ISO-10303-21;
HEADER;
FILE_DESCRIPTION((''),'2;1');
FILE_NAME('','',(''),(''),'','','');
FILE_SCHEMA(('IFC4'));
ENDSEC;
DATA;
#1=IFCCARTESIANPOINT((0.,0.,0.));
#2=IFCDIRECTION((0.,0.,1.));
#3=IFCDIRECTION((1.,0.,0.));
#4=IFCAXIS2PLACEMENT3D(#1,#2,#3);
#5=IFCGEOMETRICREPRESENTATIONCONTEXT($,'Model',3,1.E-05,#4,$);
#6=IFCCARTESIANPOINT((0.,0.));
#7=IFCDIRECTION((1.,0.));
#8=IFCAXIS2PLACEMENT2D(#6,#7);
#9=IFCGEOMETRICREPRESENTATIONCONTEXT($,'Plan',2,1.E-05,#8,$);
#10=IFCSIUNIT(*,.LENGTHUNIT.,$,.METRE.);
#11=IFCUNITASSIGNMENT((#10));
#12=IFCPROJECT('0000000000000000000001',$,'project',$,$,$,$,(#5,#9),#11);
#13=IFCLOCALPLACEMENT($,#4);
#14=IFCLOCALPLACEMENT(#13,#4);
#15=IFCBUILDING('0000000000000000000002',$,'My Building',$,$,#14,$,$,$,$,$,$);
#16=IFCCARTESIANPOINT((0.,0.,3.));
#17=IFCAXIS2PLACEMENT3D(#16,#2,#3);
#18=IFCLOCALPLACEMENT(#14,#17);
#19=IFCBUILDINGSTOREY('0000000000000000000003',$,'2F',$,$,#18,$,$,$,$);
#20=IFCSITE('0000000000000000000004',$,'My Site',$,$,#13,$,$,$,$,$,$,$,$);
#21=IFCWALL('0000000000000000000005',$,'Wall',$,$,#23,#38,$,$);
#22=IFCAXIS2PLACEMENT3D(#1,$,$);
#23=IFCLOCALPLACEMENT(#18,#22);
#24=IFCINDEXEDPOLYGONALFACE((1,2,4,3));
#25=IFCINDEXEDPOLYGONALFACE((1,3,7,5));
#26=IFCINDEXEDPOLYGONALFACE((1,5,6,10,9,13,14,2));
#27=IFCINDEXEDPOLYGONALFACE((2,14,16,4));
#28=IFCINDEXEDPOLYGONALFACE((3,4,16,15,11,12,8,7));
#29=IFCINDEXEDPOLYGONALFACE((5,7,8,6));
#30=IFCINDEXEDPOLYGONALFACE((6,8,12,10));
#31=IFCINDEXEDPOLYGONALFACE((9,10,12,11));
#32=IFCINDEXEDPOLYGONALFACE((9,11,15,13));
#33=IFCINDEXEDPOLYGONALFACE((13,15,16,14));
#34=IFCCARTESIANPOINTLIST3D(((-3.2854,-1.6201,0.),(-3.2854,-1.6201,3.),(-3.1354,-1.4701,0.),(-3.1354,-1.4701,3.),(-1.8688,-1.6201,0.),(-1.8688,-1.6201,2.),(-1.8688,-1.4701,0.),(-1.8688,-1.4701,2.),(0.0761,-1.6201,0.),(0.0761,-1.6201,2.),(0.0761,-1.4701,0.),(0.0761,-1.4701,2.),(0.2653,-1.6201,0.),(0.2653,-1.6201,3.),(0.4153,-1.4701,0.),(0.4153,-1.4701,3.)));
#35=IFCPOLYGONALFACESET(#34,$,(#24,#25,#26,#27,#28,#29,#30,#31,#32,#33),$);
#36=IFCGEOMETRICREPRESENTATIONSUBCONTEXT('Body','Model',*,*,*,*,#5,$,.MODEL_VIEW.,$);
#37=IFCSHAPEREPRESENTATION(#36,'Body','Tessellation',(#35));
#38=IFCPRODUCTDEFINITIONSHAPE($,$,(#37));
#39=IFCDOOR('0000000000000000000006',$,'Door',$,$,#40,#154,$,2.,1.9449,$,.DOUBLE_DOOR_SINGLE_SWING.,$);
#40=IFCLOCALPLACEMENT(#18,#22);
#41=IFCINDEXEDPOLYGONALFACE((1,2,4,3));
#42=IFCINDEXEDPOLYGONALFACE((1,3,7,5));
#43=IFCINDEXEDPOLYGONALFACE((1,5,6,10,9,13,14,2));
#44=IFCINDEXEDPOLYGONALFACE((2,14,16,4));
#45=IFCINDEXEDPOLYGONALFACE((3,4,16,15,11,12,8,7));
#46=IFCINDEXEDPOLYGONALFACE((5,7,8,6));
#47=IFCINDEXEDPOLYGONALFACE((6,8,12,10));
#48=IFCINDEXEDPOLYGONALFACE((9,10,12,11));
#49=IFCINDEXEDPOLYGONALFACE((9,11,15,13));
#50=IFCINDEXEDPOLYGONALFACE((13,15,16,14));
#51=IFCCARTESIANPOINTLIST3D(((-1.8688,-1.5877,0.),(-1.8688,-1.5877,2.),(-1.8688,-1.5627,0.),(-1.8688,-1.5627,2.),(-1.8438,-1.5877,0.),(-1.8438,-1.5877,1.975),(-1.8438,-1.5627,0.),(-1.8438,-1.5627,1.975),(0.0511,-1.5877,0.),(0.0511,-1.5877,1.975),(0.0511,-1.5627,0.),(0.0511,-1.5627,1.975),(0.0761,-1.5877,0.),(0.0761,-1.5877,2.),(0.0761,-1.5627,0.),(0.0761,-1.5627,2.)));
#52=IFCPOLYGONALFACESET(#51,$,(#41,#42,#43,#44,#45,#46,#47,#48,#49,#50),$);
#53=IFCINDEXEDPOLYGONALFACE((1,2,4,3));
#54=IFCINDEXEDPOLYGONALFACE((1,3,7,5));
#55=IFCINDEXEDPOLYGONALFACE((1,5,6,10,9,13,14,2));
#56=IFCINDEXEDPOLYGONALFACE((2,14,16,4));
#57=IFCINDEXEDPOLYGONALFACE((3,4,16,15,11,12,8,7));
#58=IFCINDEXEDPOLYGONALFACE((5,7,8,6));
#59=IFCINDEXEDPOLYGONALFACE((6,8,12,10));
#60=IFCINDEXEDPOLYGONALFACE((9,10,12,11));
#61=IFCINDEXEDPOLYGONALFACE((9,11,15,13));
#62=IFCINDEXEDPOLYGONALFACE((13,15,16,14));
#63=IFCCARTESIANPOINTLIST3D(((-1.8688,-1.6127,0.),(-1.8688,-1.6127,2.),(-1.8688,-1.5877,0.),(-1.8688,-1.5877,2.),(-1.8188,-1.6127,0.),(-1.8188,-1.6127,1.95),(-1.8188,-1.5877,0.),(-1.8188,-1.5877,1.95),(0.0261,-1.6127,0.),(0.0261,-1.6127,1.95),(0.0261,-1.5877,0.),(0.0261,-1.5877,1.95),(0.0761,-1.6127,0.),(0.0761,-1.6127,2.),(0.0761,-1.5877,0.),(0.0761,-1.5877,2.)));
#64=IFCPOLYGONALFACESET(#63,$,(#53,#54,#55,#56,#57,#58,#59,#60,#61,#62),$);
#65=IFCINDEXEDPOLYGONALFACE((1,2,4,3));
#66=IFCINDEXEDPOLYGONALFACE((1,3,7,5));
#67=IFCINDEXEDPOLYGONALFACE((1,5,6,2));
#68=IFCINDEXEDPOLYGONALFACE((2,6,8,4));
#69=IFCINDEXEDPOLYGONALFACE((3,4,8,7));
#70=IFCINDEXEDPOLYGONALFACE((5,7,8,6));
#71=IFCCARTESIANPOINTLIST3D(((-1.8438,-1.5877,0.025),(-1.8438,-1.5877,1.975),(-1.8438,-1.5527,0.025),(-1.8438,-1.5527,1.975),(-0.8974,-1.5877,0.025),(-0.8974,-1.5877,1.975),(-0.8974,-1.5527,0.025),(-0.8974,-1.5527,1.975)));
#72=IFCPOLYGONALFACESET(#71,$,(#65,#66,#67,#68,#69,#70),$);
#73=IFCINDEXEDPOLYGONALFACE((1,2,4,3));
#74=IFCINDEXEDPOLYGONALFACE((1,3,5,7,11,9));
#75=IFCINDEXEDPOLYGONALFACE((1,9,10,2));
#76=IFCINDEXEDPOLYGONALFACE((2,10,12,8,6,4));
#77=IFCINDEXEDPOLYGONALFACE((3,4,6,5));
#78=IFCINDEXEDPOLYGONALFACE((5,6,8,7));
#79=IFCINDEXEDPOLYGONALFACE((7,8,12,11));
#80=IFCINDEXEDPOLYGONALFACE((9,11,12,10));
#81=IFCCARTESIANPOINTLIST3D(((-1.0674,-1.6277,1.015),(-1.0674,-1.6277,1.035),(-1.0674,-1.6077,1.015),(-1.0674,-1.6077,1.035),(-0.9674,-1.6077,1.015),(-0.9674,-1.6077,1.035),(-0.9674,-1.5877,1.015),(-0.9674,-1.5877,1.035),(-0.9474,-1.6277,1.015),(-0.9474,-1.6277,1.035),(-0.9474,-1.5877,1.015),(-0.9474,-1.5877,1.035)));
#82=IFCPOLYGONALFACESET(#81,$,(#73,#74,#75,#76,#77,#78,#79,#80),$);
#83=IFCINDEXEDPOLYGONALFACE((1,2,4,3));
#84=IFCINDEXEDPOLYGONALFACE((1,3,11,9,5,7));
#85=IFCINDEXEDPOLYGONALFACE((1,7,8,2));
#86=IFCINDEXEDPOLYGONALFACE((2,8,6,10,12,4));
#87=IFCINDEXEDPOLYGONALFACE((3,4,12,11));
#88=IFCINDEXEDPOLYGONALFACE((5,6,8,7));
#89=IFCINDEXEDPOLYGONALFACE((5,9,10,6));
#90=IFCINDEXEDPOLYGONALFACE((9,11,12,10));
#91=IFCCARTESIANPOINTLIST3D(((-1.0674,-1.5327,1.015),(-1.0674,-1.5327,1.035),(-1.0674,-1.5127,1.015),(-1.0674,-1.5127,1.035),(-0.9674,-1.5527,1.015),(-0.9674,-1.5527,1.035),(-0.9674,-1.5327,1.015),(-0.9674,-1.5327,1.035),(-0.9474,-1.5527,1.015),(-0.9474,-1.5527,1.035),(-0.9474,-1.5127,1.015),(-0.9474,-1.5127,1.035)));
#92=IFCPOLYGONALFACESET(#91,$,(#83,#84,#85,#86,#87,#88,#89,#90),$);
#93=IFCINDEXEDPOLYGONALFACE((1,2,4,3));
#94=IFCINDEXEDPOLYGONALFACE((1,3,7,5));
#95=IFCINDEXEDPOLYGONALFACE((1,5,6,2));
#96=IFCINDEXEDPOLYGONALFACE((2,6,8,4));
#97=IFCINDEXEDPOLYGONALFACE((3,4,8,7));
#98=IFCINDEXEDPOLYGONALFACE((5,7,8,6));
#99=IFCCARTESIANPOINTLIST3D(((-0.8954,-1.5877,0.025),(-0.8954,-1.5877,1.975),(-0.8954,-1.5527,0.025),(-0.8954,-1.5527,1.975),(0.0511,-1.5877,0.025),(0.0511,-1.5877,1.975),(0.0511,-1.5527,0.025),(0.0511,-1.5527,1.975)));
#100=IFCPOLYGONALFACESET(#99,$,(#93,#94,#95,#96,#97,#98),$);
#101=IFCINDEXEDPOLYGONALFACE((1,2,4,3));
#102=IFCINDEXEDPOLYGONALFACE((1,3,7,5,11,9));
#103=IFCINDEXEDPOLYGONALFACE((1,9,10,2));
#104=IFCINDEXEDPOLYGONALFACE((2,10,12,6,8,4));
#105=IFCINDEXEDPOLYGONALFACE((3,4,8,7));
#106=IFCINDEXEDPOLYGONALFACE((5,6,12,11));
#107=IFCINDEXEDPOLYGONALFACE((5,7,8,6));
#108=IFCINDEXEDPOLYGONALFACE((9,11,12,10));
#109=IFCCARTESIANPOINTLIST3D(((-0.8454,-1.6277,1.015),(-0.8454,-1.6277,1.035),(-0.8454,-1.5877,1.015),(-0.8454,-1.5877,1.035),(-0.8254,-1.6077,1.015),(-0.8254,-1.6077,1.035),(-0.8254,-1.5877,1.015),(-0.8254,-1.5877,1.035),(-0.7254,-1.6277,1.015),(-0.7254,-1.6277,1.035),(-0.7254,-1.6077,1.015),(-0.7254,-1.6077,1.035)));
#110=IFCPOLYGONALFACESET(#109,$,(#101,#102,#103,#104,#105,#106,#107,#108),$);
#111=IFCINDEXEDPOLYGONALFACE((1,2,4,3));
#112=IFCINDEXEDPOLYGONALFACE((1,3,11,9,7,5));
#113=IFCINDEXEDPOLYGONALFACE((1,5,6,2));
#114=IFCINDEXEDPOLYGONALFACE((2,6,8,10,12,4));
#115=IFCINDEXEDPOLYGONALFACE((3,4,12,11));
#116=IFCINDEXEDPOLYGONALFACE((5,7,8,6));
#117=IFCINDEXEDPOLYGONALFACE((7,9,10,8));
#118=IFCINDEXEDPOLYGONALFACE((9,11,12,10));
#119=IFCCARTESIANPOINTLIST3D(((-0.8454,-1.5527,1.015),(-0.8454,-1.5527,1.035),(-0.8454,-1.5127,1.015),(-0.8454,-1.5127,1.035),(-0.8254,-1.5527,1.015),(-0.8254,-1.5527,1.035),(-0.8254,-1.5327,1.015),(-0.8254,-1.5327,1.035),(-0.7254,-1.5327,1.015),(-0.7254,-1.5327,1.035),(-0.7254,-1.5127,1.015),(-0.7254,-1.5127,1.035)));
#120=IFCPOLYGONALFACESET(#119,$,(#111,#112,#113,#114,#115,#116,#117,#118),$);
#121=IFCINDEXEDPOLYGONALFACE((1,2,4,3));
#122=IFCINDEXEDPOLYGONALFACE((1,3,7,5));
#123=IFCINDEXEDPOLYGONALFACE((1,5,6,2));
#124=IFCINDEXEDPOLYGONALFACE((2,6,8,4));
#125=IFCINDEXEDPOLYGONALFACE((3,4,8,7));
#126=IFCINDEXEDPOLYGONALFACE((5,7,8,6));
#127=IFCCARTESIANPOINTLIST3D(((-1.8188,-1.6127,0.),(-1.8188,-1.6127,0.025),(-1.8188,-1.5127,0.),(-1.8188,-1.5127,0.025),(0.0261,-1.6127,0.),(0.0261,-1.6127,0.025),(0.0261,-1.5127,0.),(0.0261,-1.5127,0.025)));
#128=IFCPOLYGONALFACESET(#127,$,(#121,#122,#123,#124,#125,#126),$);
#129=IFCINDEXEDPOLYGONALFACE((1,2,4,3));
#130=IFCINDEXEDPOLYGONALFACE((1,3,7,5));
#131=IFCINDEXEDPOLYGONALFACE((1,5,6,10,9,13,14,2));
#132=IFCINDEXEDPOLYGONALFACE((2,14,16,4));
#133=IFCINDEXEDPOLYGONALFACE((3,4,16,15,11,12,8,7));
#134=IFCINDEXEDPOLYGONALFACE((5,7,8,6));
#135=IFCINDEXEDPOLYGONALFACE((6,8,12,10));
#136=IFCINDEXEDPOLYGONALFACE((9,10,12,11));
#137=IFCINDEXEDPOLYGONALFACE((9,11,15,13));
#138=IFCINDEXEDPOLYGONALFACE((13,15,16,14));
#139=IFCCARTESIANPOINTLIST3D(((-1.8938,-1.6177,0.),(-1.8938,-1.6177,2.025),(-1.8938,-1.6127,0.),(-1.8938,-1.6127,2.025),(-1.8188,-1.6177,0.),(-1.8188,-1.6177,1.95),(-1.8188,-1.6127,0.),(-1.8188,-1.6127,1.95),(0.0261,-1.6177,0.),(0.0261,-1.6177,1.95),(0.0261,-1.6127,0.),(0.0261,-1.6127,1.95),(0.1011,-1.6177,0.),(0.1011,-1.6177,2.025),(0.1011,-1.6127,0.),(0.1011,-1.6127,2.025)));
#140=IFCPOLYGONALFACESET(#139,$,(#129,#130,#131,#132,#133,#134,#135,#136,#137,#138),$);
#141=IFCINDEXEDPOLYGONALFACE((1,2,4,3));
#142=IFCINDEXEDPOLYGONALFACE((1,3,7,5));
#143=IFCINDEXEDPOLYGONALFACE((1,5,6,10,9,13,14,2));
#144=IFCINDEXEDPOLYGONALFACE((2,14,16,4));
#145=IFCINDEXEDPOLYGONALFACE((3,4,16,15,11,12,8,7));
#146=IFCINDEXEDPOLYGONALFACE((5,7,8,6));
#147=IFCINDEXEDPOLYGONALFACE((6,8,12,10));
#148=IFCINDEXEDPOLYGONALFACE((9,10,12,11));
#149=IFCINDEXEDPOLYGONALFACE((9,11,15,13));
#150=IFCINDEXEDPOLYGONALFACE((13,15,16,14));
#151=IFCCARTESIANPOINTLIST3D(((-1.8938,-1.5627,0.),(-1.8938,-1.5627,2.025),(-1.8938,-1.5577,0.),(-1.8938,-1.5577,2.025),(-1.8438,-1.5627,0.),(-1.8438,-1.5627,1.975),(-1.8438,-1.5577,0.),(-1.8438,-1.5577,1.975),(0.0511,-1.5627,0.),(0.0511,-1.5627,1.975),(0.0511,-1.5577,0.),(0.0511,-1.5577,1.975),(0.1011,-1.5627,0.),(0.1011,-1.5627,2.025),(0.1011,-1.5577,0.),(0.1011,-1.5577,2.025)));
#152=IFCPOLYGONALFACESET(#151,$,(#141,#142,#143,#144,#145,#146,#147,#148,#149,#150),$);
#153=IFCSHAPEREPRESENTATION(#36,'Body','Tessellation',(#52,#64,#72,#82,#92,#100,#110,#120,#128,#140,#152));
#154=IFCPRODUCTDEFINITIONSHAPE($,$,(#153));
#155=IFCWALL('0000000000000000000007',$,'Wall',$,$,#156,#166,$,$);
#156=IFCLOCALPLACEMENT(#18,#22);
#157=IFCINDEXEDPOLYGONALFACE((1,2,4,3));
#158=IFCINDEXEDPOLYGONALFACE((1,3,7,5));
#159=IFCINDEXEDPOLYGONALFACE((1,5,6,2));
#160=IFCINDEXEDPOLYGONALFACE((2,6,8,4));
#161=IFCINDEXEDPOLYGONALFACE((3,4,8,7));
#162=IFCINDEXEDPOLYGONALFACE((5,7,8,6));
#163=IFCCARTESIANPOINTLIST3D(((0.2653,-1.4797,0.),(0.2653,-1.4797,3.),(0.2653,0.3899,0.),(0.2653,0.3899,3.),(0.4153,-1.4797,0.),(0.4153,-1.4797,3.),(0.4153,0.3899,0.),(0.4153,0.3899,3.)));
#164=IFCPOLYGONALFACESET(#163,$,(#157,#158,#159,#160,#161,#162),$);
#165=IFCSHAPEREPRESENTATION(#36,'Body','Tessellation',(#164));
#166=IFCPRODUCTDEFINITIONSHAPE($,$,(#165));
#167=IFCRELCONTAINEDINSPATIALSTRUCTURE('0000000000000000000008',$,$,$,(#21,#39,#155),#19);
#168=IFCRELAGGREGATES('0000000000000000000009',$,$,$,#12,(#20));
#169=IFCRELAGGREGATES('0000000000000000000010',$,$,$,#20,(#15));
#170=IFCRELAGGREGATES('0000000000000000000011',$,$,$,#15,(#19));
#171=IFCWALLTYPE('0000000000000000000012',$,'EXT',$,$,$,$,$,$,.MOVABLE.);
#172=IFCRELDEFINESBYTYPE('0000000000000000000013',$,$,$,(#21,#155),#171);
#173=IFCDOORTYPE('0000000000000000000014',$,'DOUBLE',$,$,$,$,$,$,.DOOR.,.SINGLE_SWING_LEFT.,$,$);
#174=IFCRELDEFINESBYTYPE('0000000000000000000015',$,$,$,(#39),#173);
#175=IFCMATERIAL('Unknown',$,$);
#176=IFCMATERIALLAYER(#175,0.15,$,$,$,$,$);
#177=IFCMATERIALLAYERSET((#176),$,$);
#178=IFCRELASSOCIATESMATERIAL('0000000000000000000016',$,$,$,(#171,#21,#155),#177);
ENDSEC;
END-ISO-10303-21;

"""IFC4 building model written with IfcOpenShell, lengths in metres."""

from ifc_helpers import new_model, entity, si_unit, frame, origin_with_axes, origin_2d_with_axis, place, context, subcontext, project, spatial, line, indexed_curve, outline, extrude, shape, source, transform, mapped, material, layer, layer_set, layer_usage, type_object, type_shapes, element, fill, save


model = new_model("IFC4")

# Units and contexts
model_context = context("Model", 3, precision=1e-05, world=origin_with_axes())
plan_context = context("Plan", 2, precision=1e-05, world=origin_2d_with_axis())
body_context_1 = subcontext(model_context, "Body", "Model", "MODEL_VIEW")
body_context_2 = subcontext(plan_context, "Body", "Plan", "PLAN_VIEW")
ifc_project = project(units=[si_unit("LENGTHUNIT", "METRE")], contexts=[model_context, plan_context])

# Site, building, storey
site_placement = place(None, origin_with_axes())
site = spatial("IfcSite", under=ifc_project, at=site_placement, Name="My Site")
building_placement = place(site_placement, origin_with_axes())
building = spatial("IfcBuilding", under=site, at=building_placement, Name="My Building")
storey_placement = place(building_placement, frame((0.0, 0.0, 3.0), z_axis=(0.0, 0.0, 1.0), x_axis=(1.0, 0.0, 0.0)))
storey = spatial("IfcBuildingStorey", under=building, at=storey_placement, Name="2F")

# Shared definitions
ifc_material = material(Name="Unknown")

# Shared definitions
ifc_layer_1 = layer(ifc_material, 0.15)
ifc_layer_set_1 = layer_set([ifc_layer_1])
wall_type_1 = type_object("IfcWallType", Name="EXT", PredefinedType="MOVABLE", material=ifc_layer_set_1)

# Wall, opening, door
ifc_layer_usage_1 = layer_usage(ifc_layer_set_1, "AXIS2", "POSITIVE", -0.15)
wall_1_placement = place(storey_placement, frame((0.2653, -1.6201, 0.0), z_axis=(0.0, 0.0, 1.0), x_axis=(-1.0, 0.0, 0.0)))
wall_1 = element("IfcWall", 1, at=wall_1_placement, inside=storey, type_object=wall_type_1, material=ifc_layer_usage_1, Name="Wall", context=body_context_1, shape_type="SweptSolid", body=[
    extrude(outline(indexed_curve([(-0.15, -0.15), (0.0, 0.0), (3.5507, 0.0), (3.4007, -0.15)], segments=[line(1, 2, 3, 4, 1)])), origin_with_axes(), (0.0, 0.0, 1.0), 3.0),
])
placement_1 = place(storey_placement, frame((-1.8688, -1.6127, 0.0), z_axis=(0.0, 0.0, 1.0), x_axis=(1.0, 0.0, 0.0)))
opening_1 = element("IfcOpeningElement", 2, at=placement_1, cuts=wall_1, PredefinedType="OPENING", context=body_context_1, shape_type="SweptSolid", body=[
    extrude(outline(indexed_curve([(0.0, 0.0), (1.9449, 0.0), (1.9449, 2.0), (0.0, 2.0)], segments=[line(1, 2, 3, 4, 1)])), frame((0.0, -0.6, 0.0), z_axis=(0.0, -1.0, 0.0), x_axis=(1.0, 0.0, 0.0)), (0.0, 0.0, -1.0), 1.2),
])
door_type_1 = type_object("IfcDoorType", Name="DOUBLE", OperationType="SINGLE_SWING_LEFT", PredefinedType="DOOR")
shared_shape_1 = source(origin_with_axes(), body_context_1, "Body", "SweptSolid", [
    extrude(outline(indexed_curve([(0.0, 0.0), (0.0, 2.0), (1.9449, 2.0), (1.9449, 0.0), (1.9199, 0.0), (1.9199, 1.975), (0.025, 1.975), (0.025, 0.0)], segments=[line(1, 2, 3, 4, 5, 6, 7, 8, 1)])), frame((0.0, 0.025, 0.0), z_axis=(0.0, -1.0, 0.0), x_axis=(1.0, 0.0, 0.0)), (0.0, 0.0, -1.0), 0.025),
    extrude(outline(indexed_curve([(0.0, 0.0), (0.0, 2.0), (1.9449, 2.0), (1.9449, 0.0), (1.8949, 0.0), (1.8949, 1.95), (0.05, 1.95), (0.05, 0.0)], segments=[line(1, 2, 3, 4, 5, 6, 7, 8, 1)])), frame((0.0, 0.0, 0.0), z_axis=(0.0, -1.0, 0.0), x_axis=(1.0, 0.0, 0.0)), (0.0, 0.0, -1.0), 0.025),
    extrude(outline(indexed_curve([(0.0, 0.0), (0.9465, 0.0), (0.9465, 0.035), (0.0, 0.035)], segments=[line(1, 2, 3, 4, 1)])), frame((0.025, 0.025, 0.025), z_axis=(0.0, 0.0, 1.0), x_axis=(1.0, 0.0, 0.0)), (0.0, 0.0, 1.0), 1.95),
    extrude(outline(indexed_curve([(0.0, 0.0), (0.0, -0.04), (-0.12, -0.04), (-0.12, -0.02), (-0.02, -0.02), (-0.02, 0.0)], segments=[line(1, 2, 3, 4, 5, 6, 1)])), frame((0.9215, 0.025, 1.015), z_axis=(0.0, 0.0, 1.0), x_axis=(1.0, 0.0, 0.0)), (0.0, 0.0, 1.0), 0.02),
    extrude(outline(indexed_curve([(0.0, 0.0), (0.0, 0.04), (-0.12, 0.04), (-0.12, 0.02), (-0.02, 0.02), (-0.02, 0.0)], segments=[line(1, 2, 3, 4, 5, 6, 1)])), frame((0.9215, 0.06, 1.015), z_axis=(0.0, 0.0, 1.0), x_axis=(1.0, 0.0, 0.0)), (0.0, 0.0, 1.0), 0.02),
    extrude(outline(indexed_curve([(0.0, 0.0), (-0.9465, 0.0), (-0.9465, 0.035), (0.0, 0.035)], segments=[line(1, 2, 3, 4, 1)])), frame((1.9199, 0.025, 0.025), z_axis=(0.0, 0.0, 1.0), x_axis=(1.0, 0.0, 0.0)), (0.0, 0.0, 1.0), 1.95),
    extrude(outline(indexed_curve([(0.0, 0.0), (0.0, -0.04), (0.12, -0.04), (0.12, -0.02), (0.02, -0.02), (0.02, 0.0)], segments=[line(1, 2, 3, 4, 5, 6, 1)])), frame((1.0235, 0.025, 1.015), z_axis=(0.0, 0.0, 1.0), x_axis=(1.0, 0.0, 0.0)), (0.0, 0.0, 1.0), 0.02),
    extrude(outline(indexed_curve([(0.0, 0.0), (0.0, 0.04), (0.12, 0.04), (0.12, 0.02), (0.02, 0.02), (0.02, 0.0)], segments=[line(1, 2, 3, 4, 5, 6, 1)])), frame((1.0235, 0.06, 1.015), z_axis=(0.0, 0.0, 1.0), x_axis=(1.0, 0.0, 0.0)), (0.0, 0.0, 1.0), 0.02),
    extrude(outline(indexed_curve([(0.0, 0.0), (1.8449, 0.0), (1.8449, 0.1), (0.0, 0.1)], segments=[line(1, 2, 3, 4, 1)])), frame((0.05, 0.0, 0.0), z_axis=(0.0, 0.0, 1.0), x_axis=(1.0, 0.0, 0.0)), (0.0, 0.0, 1.0), 0.025),
    extrude(outline(indexed_curve([(0.0, 0.0), (0.0, 2.025), (1.9949, 2.025), (1.9949, 0.0), (1.9199, 0.0), (1.9199, 1.95), (0.075, 1.95), (0.075, 0.0)], segments=[line(1, 2, 3, 4, 5, 6, 7, 8, 1)])), frame((-0.025, -0.005, 0.0), z_axis=(0.0, -1.0, 0.0), x_axis=(1.0, 0.0, 0.0)), (0.0, 0.0, -1.0), 0.005),
    extrude(outline(indexed_curve([(0.0, 0.0), (0.0, 2.025), (1.9949, 2.025), (1.9949, 0.0), (1.9449, 0.0), (1.9449, 1.975), (0.05, 1.975), (0.05, 0.0)], segments=[line(1, 2, 3, 4, 5, 6, 7, 8, 1)])), frame((-0.025, 0.05, 0.0), z_axis=(0.0, -1.0, 0.0), x_axis=(1.0, 0.0, 0.0)), (0.0, 0.0, -1.0), 0.005),
])
shared_shape_2 = source(origin_with_axes(), body_context_2, "Body", "Curve2D", [
    entity("IfcIndexedPolyCurve", entity("IfcCartesianPointList2D", [[0.0, 0.0], [0.0, 0.05], [0.025, 0.05], [0.025, 0.025], [0.05, 0.025], [0.05, 0.0]]), [entity("IfcLineIndex", [1, 2, 3, 4, 5, 6, 1])]),
    entity("IfcIndexedPolyCurve", entity("IfcCartesianPointList2D", [[1.9449, 0.0], [1.9449, 0.05], [1.9199, 0.05], [1.9199, 0.025], [1.8949, 0.025], [1.8949, 0.0]]), [entity("IfcLineIndex", [1, 2, 3, 4, 5, 6, 1])]),
    entity("IfcTrimmedCurve", entity("IfcEllipse", entity("IfcAxis2Placement2D", entity("IfcCartesianPoint", [0.06, 0.05]), entity("IfcDirection", [1.0, 0.0])), 0.9125, 0.9475), [entity("IfcCartesianPoint", [0.9725, 0.05])], [entity("IfcCartesianPoint", [0.06, 0.9975])], True, "CARTESIAN"),
    entity("IfcIndexedPolyCurve", entity("IfcCartesianPointList2D", [[0.025, 0.05], [0.06, 0.05], [0.06, 0.9975], [0.025, 0.9975]]), [entity("IfcLineIndex", [1, 2, 3, 4, 1])]),
    entity("IfcTrimmedCurve", entity("IfcEllipse", entity("IfcAxis2Placement2D", entity("IfcCartesianPoint", [1.8849, 0.05]), entity("IfcDirection", [1.0, 0.0])), 0.9125, 0.9475), [entity("IfcCartesianPoint", [1.8849, 0.9975])], [entity("IfcCartesianPoint", [0.9725, 0.05])], True, "CARTESIAN"),
    entity("IfcIndexedPolyCurve", entity("IfcCartesianPointList2D", [[1.9199, 0.05], [1.8849, 0.05], [1.8849, 0.9975], [1.9199, 0.9975]]), [entity("IfcLineIndex", [1, 2, 3, 4, 1])]),
])
type_shapes(door_type_1, [shared_shape_1, shared_shape_2])
door_1 = element("IfcDoor", 3, at=placement_1, inside=storey, type_object=door_type_1, Name="Door", OperationType="DOUBLE_DOOR_SINGLE_SWING", OverallHeight=2.0, OverallWidth=1.9449, shapes=[
    shape(body_context_1, "Body", "MappedRepresentation", [mapped(shared_shape_1, transform((0.0, 0.0, 0.0), x_axis=(1.0, 0.0, 0.0), y_axis=(0.0, 1.0, 0.0), z_axis=(0.0, 0.0, 1.0), scale=1.0))]),
    shape(body_context_2, "Body", "MappedRepresentation", [mapped(shared_shape_2, transform((0.0, 0.0, 0.0), x_axis=(1.0, 0.0, 0.0), y_axis=(0.0, 1.0, 0.0), z_axis=(0.0, 0.0, 1.0), scale=1.0))]),
])
fill(opening_1, door_1)

# Wall
ifc_layer_usage_2 = layer_usage(ifc_layer_set_1, "AXIS2", "POSITIVE", 0.0)
wall_2_placement = place(storey_placement, frame((0.2653, 0.3899, 0.0), z_axis=(0.0, 0.0, 1.0), x_axis=(0.0, -1.0, 0.0)))
element("IfcWall", 4, at=wall_2_placement, inside=storey, type_object=wall_type_1, material=ifc_layer_usage_2, Name="Wall", context=body_context_1, shape_type="SweptSolid", body=[
    extrude(outline(indexed_curve([(0.0, 0.0), (0.0, 0.15), (1.8696, 0.15), (1.8696, 0.0)], segments=[line(1, 2, 3, 4, 1)])), origin_with_axes(), (0.0, 0.0, 1.0), 3.0),
])

save(model, "model.ifc")
